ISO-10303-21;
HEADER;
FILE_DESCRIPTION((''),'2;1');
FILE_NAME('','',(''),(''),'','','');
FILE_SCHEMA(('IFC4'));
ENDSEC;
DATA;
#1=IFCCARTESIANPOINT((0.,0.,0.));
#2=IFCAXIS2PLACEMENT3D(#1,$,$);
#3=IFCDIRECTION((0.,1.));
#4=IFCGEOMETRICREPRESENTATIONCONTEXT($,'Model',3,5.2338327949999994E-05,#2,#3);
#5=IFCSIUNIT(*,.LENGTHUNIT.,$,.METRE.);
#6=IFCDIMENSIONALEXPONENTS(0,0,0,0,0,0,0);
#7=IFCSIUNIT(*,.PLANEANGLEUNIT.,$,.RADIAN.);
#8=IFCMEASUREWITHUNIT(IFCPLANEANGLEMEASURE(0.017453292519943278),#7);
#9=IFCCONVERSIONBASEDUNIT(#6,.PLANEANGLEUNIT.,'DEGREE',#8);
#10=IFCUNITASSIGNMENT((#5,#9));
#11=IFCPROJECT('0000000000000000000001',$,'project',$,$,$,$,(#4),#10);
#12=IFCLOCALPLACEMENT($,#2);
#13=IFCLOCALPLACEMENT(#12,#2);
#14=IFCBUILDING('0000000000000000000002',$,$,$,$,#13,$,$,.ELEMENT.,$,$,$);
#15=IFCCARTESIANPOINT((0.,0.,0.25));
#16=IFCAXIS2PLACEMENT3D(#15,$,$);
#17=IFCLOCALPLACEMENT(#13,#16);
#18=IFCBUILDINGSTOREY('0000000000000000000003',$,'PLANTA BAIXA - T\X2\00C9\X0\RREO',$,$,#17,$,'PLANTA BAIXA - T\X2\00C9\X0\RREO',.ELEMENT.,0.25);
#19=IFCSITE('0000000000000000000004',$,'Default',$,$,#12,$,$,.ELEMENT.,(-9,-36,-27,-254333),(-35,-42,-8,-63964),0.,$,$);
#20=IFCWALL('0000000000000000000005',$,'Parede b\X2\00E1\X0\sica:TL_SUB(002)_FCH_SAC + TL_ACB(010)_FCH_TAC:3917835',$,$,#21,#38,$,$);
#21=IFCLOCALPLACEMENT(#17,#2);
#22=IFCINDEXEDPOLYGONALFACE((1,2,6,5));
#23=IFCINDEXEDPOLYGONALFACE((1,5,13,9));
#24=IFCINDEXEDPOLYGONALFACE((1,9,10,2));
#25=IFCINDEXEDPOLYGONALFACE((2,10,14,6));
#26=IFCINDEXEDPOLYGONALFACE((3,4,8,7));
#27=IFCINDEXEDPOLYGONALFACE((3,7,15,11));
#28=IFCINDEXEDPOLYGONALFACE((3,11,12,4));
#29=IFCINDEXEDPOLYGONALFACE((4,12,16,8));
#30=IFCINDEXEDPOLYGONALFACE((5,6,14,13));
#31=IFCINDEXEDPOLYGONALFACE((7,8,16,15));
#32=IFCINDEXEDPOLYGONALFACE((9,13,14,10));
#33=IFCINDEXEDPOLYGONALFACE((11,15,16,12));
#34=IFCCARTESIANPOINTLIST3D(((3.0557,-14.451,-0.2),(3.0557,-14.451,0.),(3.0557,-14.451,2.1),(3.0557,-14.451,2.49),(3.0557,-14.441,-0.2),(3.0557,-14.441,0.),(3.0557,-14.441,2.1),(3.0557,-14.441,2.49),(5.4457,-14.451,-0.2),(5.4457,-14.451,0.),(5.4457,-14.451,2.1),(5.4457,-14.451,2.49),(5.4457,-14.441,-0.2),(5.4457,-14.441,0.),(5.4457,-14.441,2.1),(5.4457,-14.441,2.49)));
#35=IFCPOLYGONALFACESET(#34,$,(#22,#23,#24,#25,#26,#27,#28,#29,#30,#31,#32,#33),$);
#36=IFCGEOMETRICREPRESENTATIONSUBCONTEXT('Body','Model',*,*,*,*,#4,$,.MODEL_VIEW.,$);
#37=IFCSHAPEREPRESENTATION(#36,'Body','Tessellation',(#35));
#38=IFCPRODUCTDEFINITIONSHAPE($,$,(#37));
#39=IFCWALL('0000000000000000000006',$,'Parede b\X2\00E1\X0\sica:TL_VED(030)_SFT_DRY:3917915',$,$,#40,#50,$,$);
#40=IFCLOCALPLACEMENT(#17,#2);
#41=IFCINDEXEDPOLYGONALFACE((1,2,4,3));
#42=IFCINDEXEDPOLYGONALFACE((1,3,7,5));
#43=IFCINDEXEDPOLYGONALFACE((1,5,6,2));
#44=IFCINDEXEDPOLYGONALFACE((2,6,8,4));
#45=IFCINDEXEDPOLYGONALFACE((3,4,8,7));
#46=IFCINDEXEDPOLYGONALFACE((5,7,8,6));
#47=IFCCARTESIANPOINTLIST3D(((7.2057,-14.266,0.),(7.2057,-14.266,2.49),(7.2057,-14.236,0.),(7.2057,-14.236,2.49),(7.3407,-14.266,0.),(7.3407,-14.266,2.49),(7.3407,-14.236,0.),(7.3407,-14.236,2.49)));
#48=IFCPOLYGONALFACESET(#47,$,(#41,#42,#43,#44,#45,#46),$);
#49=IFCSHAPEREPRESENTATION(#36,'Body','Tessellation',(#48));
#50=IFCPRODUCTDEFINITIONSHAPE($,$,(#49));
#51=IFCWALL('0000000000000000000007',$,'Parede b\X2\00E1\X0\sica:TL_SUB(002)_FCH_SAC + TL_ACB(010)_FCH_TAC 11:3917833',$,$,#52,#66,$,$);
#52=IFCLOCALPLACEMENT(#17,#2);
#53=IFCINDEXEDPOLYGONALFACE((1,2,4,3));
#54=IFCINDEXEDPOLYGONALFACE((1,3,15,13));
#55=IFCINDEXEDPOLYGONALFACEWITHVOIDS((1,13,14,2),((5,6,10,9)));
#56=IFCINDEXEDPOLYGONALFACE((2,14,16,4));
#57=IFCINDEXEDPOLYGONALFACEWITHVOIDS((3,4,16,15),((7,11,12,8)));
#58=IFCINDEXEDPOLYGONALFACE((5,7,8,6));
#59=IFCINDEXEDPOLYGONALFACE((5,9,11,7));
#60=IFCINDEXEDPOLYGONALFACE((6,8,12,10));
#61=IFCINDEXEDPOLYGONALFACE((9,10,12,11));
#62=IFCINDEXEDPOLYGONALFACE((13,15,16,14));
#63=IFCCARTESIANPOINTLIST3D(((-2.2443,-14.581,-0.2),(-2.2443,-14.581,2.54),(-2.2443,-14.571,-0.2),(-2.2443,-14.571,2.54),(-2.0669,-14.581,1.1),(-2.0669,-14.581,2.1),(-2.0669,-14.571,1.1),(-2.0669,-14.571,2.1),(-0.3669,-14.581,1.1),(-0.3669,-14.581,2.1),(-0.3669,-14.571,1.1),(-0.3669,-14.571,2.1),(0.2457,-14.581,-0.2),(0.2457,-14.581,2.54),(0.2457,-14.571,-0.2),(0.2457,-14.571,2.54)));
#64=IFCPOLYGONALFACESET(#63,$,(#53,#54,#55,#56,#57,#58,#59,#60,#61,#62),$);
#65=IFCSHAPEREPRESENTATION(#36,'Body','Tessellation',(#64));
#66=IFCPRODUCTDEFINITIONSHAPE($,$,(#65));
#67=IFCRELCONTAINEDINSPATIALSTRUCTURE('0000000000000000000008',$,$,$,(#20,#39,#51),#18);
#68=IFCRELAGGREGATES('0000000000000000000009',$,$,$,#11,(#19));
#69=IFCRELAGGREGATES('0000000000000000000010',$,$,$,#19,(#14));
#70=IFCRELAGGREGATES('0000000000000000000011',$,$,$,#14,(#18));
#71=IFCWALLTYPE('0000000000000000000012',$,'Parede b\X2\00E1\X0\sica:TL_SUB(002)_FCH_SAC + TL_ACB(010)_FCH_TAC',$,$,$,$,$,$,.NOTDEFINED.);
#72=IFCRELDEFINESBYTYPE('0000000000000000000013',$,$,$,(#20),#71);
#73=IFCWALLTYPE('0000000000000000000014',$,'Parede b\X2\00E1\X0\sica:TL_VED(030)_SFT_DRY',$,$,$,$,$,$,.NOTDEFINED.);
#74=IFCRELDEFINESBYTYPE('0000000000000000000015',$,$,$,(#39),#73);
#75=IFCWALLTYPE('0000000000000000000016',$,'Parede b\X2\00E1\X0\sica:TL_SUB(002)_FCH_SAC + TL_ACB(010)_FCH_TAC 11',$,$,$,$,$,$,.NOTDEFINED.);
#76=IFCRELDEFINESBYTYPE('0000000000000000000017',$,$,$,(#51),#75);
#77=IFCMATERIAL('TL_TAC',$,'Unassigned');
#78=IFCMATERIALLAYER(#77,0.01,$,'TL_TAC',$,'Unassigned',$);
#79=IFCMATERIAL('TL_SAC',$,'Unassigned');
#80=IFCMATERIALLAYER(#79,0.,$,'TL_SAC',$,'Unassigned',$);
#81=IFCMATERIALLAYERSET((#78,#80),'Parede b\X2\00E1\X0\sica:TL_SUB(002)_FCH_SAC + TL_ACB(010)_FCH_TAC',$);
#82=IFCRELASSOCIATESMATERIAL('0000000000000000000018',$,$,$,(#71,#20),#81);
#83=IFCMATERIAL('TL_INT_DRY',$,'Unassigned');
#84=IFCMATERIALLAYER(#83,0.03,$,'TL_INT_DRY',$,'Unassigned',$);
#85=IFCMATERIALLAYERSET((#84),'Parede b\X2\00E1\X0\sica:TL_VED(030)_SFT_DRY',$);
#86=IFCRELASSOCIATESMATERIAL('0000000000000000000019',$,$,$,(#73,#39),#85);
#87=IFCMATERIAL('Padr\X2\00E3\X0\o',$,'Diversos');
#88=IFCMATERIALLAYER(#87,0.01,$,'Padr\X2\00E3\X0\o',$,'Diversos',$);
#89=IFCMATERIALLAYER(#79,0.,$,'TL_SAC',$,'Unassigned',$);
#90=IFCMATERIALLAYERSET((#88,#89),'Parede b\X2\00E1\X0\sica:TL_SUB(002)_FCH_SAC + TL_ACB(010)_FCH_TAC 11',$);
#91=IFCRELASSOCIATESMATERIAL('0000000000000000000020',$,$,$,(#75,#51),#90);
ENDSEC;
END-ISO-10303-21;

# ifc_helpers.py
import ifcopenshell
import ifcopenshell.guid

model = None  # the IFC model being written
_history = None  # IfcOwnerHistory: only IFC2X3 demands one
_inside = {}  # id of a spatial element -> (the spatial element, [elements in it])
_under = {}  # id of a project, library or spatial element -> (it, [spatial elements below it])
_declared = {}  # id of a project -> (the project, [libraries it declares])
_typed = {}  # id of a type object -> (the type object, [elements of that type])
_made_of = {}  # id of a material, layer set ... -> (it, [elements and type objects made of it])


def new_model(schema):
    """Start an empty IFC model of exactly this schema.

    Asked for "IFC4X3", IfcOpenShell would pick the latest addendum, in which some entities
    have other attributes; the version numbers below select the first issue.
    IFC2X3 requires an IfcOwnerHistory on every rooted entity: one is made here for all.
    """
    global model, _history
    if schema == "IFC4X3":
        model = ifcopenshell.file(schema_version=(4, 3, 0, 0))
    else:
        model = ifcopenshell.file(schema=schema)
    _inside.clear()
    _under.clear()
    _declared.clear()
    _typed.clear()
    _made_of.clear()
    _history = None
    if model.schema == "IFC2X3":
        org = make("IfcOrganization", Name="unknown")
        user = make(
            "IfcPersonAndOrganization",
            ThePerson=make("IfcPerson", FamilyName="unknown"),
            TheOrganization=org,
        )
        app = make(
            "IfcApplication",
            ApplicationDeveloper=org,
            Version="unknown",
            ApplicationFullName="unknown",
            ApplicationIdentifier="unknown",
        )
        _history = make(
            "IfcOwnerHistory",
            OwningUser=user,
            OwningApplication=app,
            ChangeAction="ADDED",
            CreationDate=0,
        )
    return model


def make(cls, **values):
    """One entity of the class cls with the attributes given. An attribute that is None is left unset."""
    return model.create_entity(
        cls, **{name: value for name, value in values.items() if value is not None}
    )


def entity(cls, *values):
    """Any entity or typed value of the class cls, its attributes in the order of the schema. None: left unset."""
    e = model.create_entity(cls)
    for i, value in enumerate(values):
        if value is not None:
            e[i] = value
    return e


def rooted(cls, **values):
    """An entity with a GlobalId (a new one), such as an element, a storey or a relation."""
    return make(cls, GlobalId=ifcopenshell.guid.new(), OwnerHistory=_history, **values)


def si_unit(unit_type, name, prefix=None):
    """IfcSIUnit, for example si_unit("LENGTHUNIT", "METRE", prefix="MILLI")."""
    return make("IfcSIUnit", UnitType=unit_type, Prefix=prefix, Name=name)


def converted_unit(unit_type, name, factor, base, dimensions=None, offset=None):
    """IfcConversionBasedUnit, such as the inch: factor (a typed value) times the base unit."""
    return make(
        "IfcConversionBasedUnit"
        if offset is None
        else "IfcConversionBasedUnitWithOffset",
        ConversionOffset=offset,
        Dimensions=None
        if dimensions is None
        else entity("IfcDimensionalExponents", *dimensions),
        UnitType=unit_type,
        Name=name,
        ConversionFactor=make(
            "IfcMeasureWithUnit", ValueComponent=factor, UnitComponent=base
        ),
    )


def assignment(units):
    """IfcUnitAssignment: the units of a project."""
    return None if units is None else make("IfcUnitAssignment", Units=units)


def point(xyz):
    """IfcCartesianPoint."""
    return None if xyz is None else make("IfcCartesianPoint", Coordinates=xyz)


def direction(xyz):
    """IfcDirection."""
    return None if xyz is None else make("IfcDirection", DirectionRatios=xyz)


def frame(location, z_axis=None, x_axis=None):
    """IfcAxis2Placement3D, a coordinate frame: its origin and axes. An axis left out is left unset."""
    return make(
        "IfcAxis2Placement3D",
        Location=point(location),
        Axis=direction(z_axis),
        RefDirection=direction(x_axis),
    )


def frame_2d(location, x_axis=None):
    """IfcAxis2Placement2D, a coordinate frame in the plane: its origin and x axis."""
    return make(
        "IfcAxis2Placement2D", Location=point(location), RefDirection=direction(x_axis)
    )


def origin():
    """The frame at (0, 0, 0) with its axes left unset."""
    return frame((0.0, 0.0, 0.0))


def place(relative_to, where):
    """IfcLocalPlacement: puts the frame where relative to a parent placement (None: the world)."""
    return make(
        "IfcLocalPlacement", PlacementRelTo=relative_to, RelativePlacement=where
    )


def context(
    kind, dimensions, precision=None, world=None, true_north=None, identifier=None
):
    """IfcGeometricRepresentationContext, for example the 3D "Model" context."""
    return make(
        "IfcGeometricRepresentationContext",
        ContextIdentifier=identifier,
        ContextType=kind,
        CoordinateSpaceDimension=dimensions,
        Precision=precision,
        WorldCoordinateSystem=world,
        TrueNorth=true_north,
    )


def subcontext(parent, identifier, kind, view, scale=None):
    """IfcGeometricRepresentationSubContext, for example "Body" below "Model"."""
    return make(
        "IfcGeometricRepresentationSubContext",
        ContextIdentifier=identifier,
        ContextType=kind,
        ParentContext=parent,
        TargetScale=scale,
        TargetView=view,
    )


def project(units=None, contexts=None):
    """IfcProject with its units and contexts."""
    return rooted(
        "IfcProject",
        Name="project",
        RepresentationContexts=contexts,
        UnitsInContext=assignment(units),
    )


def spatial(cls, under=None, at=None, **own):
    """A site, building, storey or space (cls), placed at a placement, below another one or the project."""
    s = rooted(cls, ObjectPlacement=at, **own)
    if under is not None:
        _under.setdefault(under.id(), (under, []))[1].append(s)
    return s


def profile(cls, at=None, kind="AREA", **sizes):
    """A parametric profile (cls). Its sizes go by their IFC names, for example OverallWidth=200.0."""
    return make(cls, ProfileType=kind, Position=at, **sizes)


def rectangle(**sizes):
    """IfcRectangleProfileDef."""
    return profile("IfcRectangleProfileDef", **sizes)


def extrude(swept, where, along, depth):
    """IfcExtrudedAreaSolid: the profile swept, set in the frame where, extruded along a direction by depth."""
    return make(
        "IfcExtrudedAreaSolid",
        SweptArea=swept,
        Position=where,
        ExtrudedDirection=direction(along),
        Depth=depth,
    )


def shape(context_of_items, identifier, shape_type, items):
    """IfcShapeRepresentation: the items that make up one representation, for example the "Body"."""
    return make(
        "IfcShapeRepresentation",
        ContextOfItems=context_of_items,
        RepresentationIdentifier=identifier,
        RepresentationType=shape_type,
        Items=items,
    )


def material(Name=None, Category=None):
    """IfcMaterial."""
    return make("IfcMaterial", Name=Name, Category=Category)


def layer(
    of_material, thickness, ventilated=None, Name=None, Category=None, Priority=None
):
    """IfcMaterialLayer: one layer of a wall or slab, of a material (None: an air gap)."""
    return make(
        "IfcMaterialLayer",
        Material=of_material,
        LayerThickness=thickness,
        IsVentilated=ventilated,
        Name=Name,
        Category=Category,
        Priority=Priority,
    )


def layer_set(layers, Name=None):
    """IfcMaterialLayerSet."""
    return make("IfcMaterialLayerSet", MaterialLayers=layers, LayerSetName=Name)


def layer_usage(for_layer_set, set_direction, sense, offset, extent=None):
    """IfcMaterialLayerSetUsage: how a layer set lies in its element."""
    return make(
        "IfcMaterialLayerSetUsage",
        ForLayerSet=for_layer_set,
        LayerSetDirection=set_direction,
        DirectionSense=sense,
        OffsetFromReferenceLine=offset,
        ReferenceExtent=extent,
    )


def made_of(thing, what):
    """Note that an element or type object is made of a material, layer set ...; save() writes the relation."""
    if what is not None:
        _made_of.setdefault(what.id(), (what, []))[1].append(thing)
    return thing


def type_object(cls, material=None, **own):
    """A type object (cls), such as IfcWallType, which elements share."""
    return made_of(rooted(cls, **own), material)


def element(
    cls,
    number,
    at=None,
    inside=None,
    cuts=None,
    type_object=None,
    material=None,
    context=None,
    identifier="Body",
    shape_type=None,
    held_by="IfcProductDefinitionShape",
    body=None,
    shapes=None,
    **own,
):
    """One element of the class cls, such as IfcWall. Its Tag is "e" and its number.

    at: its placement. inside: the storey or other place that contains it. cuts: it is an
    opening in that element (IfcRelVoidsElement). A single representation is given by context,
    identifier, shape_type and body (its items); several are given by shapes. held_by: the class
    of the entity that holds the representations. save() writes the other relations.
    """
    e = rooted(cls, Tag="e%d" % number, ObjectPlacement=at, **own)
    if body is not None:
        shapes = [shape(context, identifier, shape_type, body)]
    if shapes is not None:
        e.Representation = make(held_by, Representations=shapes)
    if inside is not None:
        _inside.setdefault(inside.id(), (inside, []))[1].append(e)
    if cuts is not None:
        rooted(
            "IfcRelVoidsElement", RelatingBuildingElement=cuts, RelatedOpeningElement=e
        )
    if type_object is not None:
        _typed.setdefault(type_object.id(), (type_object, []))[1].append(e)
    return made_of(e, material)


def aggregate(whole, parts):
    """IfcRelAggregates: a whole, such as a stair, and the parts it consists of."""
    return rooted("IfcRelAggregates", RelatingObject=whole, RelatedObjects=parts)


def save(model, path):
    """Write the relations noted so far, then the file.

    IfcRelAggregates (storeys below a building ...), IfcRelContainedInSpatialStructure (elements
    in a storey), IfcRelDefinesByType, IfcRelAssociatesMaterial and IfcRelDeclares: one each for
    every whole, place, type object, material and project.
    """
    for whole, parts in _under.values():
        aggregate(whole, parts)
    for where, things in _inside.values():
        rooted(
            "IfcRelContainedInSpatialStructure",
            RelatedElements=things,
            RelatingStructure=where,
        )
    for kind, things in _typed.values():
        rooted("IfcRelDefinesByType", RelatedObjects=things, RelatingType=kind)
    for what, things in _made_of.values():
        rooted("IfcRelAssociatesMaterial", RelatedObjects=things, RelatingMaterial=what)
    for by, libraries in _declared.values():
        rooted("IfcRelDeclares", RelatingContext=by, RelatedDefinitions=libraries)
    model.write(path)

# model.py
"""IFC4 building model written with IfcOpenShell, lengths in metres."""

from ifc_helpers import new_model, entity, si_unit, converted_unit, direction, frame, frame_2d, origin, place, context, subcontext, project, spatial, rectangle, extrude, material, layer, layer_set, layer_usage, type_object, element, save


model = new_model("IFC4")

# Units and contexts
model_context = context("Model", 3, precision=5.2338327949999994e-05, world=origin(), true_north=direction((0.0, 1.0)))
body_context = subcontext(model_context, "Body", "Model", "MODEL_VIEW")
ifc_project = project(units=[si_unit("LENGTHUNIT", "METRE"), converted_unit("PLANEANGLEUNIT", "DEGREE", entity("IfcPlaneAngleMeasure", 0.017453292519943278), si_unit("PLANEANGLEUNIT", "RADIAN"), dimensions=[0, 0, 0, 0, 0, 0, 0])], contexts=[model_context])

# Site, building, storey
site_placement = place(None, frame((0.0, 0.0, 0.0)))
site = spatial("IfcSite", under=ifc_project, at=site_placement, Name="Default", CompositionType="ELEMENT", RefLatitude=(-9, -36, -27, -254333), RefLongitude=(-35, -42, -8, -63964), RefElevation=0.0)
building_placement = place(site_placement, origin())
building = spatial("IfcBuilding", under=site, at=building_placement, CompositionType="ELEMENT")
storey_placement = place(building_placement, frame((0.0, 0.0, 0.25)))
storey = spatial("IfcBuildingStorey", under=building, at=storey_placement, Name="PLANTA BAIXA - TÉRREO", LongName="PLANTA BAIXA - TÉRREO", CompositionType="ELEMENT", Elevation=0.25)

# Shared definitions
ifc_material_1 = material(Name="TL_SAC", Category="Unassigned")

# Wall, opening
ifc_material_2 = material(Name="TL_TAC", Category="Unassigned")
ifc_layer_1 = layer(ifc_material_2, 0.01, Name="TL_TAC", Category="Unassigned")
ifc_layer_2 = layer(ifc_material_1, 0.0, Name="TL_SAC", Category="Unassigned")
ifc_layer_set_1 = layer_set([ifc_layer_1, ifc_layer_2], Name="Parede básica:TL_SUB(002)_FCH_SAC + TL_ACB(010)_FCH_TAC")
ifc_layer_usage_1 = layer_usage(ifc_layer_set_1, "AXIS2", "POSITIVE", -0.005)
wall_type_1 = type_object("IfcWallType", Name="Parede básica:TL_SUB(002)_FCH_SAC + TL_ACB(010)_FCH_TAC", PredefinedType="NOTDEFINED", material=ifc_layer_set_1)
wall_1_placement = place(storey_placement, frame((5.4457, -14.446, -0.2), z_axis=(0.0, 0.0, 1.0), x_axis=(-1.0, 0.0, 0.0)))
wall_1 = element("IfcWall", 1, at=wall_1_placement, inside=storey, type_object=wall_type_1, material=ifc_layer_usage_1, Name="Parede básica:TL_SUB(002)_FCH_SAC + TL_ACB(010)_FCH_TAC:3917835", context=body_context, shape_type="SweptSolid", body=[
    extrude(rectangle(XDim=2.39, YDim=0.01, at=frame_2d((1.195, 0.0), x_axis=(-1.0, 0.0))), origin(), (0.0, 0.0, 1.0), 2.69),
])
opening_1_placement = place(wall_1_placement, frame((5.4457, -14.446, 0.2)))
element("IfcOpeningElement", 2, at=opening_1_placement, cuts=wall_1, PredefinedType="OPENING", context=body_context, shape_type="SweptSolid", body=[
    extrude(rectangle(XDim=2.1, YDim=2.4, at=frame_2d((0.0, 0.0), x_axis=(0.0, 1.0))), frame((-4.2557, 12.927, 1.05), z_axis=(0.0, 1.0, 0.0), x_axis=(-1.0, 0.0, 0.0)), (0.0, 0.0, 1.0), 3.048),
])

# Wall
ifc_material_3 = material(Name="TL_INT_DRY", Category="Unassigned")
ifc_layer_3 = layer(ifc_material_3, 0.03, Name="TL_INT_DRY", Category="Unassigned")
ifc_layer_set_2 = layer_set([ifc_layer_3], Name="Parede básica:TL_VED(030)_SFT_DRY")
ifc_layer_usage_2 = layer_usage(ifc_layer_set_2, "AXIS2", "POSITIVE", -0.015)
wall_type_2 = type_object("IfcWallType", Name="Parede básica:TL_VED(030)_SFT_DRY", PredefinedType="NOTDEFINED", material=ifc_layer_set_2)
wall_2_placement = place(storey_placement, frame((7.2057, -14.251, 0.0)))
element("IfcWall", 3, at=wall_2_placement, inside=storey, type_object=wall_type_2, material=ifc_layer_usage_2, Name="Parede básica:TL_VED(030)_SFT_DRY:3917915", context=body_context, shape_type="SweptSolid", body=[
    extrude(rectangle(XDim=0.135, YDim=0.03, at=frame_2d((0.0675, 0.0), x_axis=(-1.0, 0.0))), origin(), (0.0, 0.0, 1.0), 2.49),
])

# Wall, opening
ifc_material_4 = material(Name="Padrão", Category="Diversos")
ifc_layer_4 = layer(ifc_material_4, 0.01, Name="Padrão", Category="Diversos")
ifc_layer_5 = layer(ifc_material_1, 0.0, Name="TL_SAC", Category="Unassigned")
ifc_layer_set_3 = layer_set([ifc_layer_4, ifc_layer_5], Name="Parede básica:TL_SUB(002)_FCH_SAC + TL_ACB(010)_FCH_TAC 11")
ifc_layer_usage_3 = layer_usage(ifc_layer_set_3, "AXIS2", "NEGATIVE", 0.005)
wall_type_3 = type_object("IfcWallType", Name="Parede básica:TL_SUB(002)_FCH_SAC + TL_ACB(010)_FCH_TAC 11", PredefinedType="NOTDEFINED", material=ifc_layer_set_3)
wall_3_placement = place(storey_placement, frame((0.2457, -14.576, -0.2), z_axis=(0.0, 0.0, 1.0), x_axis=(-1.0, 0.0, 0.0)))
wall_3 = element("IfcWall", 4, at=wall_3_placement, inside=storey, type_object=wall_type_3, material=ifc_layer_usage_3, Name="Parede básica:TL_SUB(002)_FCH_SAC + TL_ACB(010)_FCH_TAC 11:3917833", context=body_context, shape_type="SweptSolid", body=[
    extrude(rectangle(XDim=2.49, YDim=0.01, at=frame_2d((1.245, 0.0), x_axis=(-1.0, 0.0))), origin(), (0.0, 0.0, 1.0), 2.74),
])
opening_2_placement = place(wall_3_placement, frame((0.2457, -14.576, 1.3)))
element("IfcOpeningElement", 5, at=opening_2_placement, cuts=wall_3, PredefinedType="OPENING", context=body_context, shape_type="SweptSolid", body=[
    extrude(rectangle(XDim=1.0, YDim=1.7, at=frame_2d((0.0, 0.0), x_axis=(0.0, 1.0))), frame((1.2169, 13.157, 0.5), z_axis=(0.0, 1.0, 0.0), x_axis=(1.0, 0.0, 0.0)), (0.0, 0.0, 1.0), 3.048),
])

save(model, "model.ifc")
